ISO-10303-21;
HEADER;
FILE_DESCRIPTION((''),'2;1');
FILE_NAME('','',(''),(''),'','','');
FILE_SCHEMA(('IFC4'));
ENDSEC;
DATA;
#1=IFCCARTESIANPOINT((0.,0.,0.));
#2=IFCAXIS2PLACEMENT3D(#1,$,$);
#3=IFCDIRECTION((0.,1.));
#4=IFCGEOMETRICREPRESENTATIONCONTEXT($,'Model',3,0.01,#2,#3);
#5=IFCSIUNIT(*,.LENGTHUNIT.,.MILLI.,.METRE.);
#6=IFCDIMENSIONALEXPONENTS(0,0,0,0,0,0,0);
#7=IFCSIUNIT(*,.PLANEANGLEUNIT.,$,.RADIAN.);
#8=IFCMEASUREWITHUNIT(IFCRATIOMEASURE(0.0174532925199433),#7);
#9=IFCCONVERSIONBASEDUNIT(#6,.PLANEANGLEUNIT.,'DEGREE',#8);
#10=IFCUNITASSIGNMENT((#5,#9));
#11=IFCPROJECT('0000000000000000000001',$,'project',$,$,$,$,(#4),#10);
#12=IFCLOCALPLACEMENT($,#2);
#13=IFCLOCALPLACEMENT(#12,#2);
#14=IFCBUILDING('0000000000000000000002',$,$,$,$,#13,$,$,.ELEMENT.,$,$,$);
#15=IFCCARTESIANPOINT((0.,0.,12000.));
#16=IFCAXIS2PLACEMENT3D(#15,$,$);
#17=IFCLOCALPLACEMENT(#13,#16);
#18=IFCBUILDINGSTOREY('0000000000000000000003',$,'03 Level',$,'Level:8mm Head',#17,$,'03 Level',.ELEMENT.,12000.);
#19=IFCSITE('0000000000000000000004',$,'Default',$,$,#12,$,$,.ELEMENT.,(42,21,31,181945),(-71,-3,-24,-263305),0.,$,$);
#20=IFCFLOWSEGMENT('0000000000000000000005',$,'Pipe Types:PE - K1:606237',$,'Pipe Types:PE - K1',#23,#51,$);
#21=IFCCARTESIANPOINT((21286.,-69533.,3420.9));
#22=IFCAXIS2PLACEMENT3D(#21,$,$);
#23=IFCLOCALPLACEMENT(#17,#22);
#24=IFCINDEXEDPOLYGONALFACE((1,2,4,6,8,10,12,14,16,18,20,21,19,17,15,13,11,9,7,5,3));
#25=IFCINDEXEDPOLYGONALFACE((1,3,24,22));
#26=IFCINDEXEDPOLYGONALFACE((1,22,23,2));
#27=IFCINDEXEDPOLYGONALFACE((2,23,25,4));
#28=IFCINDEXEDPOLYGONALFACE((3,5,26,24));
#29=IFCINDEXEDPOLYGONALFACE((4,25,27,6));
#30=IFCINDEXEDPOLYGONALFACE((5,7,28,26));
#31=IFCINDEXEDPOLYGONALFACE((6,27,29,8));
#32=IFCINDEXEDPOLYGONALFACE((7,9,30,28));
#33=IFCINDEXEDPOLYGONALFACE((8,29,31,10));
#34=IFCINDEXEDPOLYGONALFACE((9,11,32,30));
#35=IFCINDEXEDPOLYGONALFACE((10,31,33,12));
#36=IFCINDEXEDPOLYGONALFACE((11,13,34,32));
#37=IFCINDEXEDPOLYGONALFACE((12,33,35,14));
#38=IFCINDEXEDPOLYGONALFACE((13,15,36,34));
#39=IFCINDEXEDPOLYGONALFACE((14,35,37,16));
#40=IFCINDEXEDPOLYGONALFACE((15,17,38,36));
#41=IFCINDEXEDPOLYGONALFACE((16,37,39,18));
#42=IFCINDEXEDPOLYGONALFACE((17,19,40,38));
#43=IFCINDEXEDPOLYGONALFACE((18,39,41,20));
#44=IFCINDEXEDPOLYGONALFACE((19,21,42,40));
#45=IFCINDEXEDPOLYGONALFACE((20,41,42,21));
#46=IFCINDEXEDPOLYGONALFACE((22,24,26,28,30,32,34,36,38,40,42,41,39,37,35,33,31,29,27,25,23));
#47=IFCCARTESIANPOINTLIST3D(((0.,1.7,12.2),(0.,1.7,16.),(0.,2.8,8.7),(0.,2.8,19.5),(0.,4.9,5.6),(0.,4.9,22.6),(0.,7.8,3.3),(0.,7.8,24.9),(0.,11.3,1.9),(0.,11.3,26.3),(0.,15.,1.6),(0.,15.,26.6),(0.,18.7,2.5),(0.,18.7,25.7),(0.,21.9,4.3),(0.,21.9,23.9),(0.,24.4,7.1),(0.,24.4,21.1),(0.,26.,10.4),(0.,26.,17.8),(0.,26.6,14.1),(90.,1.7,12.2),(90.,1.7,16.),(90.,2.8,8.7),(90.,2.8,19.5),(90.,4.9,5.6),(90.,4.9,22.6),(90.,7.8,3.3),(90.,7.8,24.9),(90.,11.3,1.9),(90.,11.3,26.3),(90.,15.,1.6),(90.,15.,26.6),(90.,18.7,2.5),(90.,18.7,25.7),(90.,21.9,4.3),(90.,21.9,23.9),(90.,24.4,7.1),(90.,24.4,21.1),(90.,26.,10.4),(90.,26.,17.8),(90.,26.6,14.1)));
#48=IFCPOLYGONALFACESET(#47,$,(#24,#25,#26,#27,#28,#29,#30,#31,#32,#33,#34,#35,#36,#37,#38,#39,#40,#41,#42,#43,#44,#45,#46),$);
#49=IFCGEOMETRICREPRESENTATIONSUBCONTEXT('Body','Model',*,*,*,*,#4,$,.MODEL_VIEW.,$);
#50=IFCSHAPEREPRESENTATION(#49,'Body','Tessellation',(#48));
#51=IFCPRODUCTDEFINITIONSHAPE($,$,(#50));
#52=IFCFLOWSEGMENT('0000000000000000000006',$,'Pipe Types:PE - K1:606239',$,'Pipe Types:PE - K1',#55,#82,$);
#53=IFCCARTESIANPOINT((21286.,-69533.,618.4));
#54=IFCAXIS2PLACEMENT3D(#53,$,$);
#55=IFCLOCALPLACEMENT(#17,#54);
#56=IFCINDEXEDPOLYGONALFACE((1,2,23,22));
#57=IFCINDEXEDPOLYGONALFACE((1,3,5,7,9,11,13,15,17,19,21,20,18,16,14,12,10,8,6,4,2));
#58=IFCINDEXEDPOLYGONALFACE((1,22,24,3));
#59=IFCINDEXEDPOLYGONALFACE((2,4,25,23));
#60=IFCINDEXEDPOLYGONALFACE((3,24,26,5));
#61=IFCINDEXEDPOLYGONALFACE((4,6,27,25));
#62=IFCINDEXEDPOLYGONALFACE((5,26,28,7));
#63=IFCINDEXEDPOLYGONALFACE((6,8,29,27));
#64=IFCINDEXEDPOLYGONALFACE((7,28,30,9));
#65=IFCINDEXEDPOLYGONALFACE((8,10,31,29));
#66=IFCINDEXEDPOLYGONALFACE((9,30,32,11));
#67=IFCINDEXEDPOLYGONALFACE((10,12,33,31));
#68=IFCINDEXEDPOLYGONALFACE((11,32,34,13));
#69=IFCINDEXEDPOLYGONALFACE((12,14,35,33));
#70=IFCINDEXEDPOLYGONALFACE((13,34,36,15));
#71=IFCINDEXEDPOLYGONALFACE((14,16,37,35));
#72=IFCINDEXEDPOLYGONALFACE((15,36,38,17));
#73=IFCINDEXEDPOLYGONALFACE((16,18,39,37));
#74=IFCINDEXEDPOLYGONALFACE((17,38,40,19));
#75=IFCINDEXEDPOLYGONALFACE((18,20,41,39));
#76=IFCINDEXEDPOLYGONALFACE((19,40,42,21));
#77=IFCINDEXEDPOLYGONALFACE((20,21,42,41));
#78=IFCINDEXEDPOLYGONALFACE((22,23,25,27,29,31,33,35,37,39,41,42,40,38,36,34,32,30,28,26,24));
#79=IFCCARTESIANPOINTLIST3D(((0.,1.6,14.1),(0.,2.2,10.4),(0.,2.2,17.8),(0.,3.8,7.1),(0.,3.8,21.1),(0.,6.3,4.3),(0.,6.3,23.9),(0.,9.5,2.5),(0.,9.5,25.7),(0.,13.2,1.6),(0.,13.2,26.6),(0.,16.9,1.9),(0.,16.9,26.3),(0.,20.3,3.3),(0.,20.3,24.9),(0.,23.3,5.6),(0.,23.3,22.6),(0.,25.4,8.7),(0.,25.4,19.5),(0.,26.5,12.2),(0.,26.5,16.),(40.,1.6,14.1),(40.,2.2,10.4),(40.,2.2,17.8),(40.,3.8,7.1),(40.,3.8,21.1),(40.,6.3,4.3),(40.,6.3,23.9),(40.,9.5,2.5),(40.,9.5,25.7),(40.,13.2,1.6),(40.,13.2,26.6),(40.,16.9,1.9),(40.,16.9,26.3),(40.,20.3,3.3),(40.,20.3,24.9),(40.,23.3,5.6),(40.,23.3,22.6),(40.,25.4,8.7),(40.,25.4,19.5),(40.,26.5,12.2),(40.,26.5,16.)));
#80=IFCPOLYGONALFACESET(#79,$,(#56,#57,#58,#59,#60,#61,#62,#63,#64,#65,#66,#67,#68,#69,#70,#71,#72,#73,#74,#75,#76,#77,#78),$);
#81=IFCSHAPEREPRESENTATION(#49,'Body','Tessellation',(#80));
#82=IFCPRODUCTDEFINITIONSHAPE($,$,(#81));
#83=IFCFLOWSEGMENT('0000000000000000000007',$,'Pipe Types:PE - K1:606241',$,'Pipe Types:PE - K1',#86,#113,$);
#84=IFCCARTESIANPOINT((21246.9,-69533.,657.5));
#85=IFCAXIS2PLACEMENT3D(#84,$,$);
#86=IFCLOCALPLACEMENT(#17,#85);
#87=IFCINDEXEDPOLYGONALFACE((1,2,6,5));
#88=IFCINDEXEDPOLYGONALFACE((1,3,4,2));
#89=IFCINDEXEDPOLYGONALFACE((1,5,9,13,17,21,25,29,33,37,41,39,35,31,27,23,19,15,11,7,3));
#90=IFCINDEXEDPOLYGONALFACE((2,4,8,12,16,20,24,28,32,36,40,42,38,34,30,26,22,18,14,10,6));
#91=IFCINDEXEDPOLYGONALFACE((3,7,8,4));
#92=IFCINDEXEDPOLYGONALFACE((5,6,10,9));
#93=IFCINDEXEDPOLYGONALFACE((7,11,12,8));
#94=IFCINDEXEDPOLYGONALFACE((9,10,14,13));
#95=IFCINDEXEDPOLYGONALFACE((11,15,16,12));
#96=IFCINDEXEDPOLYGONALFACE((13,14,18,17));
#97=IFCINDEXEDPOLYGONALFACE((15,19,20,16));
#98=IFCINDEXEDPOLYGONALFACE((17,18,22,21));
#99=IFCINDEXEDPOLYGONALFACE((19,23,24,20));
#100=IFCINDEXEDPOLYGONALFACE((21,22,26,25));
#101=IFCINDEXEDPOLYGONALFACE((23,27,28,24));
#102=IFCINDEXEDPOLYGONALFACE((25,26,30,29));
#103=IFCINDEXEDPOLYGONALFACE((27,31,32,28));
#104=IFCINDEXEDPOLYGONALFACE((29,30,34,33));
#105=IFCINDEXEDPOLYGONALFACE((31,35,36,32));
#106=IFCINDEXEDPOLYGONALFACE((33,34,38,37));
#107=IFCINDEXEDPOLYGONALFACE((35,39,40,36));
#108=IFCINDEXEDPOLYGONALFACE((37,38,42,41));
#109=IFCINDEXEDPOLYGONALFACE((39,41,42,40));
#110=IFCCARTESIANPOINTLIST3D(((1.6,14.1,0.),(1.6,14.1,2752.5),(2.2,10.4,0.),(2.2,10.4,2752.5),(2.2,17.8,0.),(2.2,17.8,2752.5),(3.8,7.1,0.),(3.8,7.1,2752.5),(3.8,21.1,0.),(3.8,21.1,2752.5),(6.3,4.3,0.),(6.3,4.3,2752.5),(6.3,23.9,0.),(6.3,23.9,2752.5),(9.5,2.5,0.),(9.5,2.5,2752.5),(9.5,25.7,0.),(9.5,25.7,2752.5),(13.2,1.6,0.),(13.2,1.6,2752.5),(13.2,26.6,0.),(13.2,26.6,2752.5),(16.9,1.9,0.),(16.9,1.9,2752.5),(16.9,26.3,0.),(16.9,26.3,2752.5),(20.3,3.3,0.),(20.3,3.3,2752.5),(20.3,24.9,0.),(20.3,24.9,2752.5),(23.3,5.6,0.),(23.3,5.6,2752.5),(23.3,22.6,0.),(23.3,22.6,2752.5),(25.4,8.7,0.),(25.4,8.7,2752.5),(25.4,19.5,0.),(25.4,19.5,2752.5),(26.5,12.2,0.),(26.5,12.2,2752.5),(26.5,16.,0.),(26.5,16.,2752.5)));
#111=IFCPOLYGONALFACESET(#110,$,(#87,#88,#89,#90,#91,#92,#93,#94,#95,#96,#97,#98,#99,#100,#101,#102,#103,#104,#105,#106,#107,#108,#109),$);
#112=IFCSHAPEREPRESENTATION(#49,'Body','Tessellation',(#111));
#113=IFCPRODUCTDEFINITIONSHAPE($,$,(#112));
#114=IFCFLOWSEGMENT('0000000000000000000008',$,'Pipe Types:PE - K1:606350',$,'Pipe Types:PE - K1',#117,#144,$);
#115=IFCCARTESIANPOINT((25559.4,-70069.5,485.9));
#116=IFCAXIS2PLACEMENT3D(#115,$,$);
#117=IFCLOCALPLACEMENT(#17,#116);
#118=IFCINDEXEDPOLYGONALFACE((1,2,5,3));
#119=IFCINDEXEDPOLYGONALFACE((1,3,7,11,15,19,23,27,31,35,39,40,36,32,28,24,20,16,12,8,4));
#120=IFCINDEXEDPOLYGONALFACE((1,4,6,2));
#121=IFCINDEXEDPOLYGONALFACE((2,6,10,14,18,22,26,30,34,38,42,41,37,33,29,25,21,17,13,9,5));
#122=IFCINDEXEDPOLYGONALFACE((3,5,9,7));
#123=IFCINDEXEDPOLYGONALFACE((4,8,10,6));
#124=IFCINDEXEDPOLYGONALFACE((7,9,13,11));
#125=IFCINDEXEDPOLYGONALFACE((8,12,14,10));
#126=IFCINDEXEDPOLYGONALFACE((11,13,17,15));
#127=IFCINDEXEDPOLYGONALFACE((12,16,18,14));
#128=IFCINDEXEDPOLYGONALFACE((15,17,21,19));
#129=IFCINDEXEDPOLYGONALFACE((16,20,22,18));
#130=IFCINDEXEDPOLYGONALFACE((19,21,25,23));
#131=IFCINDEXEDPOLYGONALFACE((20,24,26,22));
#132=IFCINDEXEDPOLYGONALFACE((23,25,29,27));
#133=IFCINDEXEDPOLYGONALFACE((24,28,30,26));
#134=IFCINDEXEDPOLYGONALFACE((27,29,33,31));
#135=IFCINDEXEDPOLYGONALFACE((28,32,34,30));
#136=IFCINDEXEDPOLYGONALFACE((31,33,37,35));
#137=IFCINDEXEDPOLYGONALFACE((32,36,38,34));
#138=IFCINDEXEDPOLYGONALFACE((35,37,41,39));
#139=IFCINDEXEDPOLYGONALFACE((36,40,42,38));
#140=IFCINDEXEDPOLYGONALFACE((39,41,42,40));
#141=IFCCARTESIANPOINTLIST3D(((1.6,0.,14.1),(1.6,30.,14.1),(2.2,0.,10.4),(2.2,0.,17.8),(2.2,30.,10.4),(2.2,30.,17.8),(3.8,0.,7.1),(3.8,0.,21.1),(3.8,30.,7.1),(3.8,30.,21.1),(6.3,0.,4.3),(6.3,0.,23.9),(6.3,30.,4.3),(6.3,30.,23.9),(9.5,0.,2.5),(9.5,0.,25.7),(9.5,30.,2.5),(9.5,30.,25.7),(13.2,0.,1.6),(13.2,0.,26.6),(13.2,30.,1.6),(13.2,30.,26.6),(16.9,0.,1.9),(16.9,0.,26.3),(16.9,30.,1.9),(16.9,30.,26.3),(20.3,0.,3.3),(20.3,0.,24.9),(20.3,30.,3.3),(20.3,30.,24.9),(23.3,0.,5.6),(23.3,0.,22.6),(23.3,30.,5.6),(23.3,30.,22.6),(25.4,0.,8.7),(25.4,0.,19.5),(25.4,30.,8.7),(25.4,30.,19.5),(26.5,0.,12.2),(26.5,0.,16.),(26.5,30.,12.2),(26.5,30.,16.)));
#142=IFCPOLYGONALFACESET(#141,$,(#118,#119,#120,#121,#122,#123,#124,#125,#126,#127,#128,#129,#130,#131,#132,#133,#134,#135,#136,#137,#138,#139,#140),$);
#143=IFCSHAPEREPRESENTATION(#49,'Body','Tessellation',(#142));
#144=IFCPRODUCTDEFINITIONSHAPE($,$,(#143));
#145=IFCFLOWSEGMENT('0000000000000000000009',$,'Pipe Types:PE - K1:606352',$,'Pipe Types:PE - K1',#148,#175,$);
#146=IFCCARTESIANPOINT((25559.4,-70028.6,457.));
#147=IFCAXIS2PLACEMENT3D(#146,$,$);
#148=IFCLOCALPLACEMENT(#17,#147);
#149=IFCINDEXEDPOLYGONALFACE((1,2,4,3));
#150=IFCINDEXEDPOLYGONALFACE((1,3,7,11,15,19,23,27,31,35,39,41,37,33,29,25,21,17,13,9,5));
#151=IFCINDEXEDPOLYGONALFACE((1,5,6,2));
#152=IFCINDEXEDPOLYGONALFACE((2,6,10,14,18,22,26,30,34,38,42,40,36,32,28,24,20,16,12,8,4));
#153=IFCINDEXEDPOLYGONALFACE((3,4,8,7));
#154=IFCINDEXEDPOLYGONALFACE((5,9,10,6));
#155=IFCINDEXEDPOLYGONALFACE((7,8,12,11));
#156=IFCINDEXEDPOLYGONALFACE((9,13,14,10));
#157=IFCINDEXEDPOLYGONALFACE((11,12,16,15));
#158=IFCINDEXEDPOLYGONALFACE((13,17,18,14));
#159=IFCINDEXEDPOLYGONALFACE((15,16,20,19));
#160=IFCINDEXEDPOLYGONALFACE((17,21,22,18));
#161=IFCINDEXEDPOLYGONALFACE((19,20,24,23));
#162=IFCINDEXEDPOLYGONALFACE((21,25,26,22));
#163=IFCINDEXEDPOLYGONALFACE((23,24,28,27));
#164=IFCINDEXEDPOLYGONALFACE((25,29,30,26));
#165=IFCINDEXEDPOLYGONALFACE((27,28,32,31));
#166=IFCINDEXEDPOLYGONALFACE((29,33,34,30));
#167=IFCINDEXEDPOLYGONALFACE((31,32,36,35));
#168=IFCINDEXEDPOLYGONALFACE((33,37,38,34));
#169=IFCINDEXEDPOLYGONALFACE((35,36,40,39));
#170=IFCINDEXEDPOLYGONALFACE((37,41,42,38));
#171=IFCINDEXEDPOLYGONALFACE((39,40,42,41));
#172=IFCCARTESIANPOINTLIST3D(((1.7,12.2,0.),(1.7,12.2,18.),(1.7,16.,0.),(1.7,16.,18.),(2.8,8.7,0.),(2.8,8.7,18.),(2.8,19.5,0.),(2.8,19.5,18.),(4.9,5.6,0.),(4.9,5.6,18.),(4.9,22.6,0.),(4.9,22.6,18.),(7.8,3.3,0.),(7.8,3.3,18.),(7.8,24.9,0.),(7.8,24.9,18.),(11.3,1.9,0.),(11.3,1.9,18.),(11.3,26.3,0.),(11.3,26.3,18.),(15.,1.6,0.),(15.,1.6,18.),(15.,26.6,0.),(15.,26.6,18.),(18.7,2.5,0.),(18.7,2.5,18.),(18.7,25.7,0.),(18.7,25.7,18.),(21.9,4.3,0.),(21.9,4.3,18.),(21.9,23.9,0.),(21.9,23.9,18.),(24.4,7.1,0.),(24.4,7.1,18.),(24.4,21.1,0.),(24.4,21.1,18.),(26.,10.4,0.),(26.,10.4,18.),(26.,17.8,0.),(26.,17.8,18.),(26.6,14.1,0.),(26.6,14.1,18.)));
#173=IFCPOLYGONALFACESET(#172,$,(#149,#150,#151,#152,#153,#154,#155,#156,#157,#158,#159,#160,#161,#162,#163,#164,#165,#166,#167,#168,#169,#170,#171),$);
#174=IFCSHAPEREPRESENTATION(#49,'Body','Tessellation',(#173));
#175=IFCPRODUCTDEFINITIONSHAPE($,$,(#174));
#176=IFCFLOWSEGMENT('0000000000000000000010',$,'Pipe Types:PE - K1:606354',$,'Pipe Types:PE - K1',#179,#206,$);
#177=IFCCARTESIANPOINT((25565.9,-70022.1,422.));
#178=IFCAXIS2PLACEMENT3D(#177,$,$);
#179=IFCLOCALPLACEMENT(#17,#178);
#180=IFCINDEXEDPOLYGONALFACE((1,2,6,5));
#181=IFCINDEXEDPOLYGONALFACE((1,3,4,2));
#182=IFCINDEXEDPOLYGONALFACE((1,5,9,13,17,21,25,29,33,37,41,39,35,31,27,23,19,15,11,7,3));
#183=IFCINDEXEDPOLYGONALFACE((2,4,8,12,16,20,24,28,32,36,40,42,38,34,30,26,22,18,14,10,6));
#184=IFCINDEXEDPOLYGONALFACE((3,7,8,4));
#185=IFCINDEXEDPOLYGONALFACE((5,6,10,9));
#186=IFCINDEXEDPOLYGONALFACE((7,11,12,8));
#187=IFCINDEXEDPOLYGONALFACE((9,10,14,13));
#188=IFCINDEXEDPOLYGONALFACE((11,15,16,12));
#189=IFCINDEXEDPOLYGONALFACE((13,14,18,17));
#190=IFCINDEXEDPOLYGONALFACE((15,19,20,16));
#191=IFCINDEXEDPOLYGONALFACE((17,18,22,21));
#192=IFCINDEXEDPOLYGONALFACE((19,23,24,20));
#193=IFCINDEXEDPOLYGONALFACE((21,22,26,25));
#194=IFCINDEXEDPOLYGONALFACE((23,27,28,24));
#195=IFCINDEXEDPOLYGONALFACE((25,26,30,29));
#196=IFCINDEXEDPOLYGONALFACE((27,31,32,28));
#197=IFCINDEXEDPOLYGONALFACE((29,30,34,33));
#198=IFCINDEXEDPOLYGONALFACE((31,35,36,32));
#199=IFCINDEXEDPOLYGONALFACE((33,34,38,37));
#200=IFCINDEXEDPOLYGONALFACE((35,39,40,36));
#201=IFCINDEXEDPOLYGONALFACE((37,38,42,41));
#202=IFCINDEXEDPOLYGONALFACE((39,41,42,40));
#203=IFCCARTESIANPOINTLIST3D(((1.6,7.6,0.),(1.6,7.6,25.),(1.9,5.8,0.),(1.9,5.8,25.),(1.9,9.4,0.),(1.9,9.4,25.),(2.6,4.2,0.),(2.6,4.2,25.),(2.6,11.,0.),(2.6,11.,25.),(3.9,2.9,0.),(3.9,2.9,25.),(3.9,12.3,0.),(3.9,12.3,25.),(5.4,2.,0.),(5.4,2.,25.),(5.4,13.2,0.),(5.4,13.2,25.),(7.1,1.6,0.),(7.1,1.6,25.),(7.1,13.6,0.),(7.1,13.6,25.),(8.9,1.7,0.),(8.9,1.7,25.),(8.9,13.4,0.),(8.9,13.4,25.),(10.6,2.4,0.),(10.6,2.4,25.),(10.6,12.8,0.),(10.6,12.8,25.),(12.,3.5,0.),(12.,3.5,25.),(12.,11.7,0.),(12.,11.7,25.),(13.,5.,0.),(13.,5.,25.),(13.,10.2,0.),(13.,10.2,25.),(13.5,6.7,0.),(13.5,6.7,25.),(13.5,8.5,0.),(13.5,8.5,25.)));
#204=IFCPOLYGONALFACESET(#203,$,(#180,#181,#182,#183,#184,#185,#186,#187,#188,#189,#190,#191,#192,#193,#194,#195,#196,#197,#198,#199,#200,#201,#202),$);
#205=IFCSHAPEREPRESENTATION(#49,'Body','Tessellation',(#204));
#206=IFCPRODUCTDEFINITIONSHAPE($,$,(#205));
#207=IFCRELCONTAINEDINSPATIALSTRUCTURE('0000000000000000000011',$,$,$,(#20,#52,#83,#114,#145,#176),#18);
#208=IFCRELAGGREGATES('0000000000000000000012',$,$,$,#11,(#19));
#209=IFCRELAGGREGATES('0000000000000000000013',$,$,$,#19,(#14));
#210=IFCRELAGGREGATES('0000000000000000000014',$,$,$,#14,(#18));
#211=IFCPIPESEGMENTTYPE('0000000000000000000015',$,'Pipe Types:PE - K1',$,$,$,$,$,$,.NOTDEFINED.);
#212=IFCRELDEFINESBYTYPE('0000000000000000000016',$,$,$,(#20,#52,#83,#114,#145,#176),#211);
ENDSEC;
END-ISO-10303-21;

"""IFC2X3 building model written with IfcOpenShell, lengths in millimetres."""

from ifc_helpers import new_model, entity, si_unit, converted_unit, direction, frame, frame_2d, origin, origin_2d_with_axis, place, context, subcontext, project, spatial, circle, extrude, type_object, element, save


model = new_model("IFC2X3")

# Units and contexts
model_context = context("Model", 3, precision=0.01, world=origin(), true_north=direction((0.0, 1.0)))
body_context = subcontext(model_context, "Body", "Model", "MODEL_VIEW")
ifc_project = project(units=[si_unit("LENGTHUNIT", "METRE", prefix="MILLI"), converted_unit("PLANEANGLEUNIT", "DEGREE", entity("IfcRatioMeasure", 0.0174532925199433), si_unit("PLANEANGLEUNIT", "RADIAN"), dimensions=[0, 0, 0, 0, 0, 0, 0])], contexts=[model_context])

# Site, building, storey
site_placement = place(None, origin())
site = spatial("IfcSite", under=ifc_project, at=site_placement, Name="Default", CompositionType="ELEMENT", RefLatitude=(42, 21, 31, 181945), RefLongitude=(-71, -3, -24, -263305), RefElevation=0.0)
building_placement = place(site_placement, origin())
building = spatial("IfcBuilding", under=site, at=building_placement, CompositionType="ELEMENT")
storey_placement = place(building_placement, frame((0.0, 0.0, 12000.0)))
storey = spatial("IfcBuildingStorey", under=building, at=storey_placement, Name="03 Level", ObjectType="Level:8mm Head", LongName="03 Level", CompositionType="ELEMENT", Elevation=12000.0)

# Flow segments
pipe_segment_type = type_object("IfcPipeSegmentType", Name="Pipe Types:PE - K1", PredefinedType="NOTDEFINED")
flow_segment_1_placement = place(storey_placement, frame((21286.0, -69533.0, 3420.9)))
element("IfcFlowSegment", 1, at=flow_segment_1_placement, inside=storey, type_object=pipe_segment_type, Name="Pipe Types:PE - K1:606237", ObjectType="Pipe Types:PE - K1", context=body_context, shape_type="SweptSolid", body=[
    extrude(circle(Radius=12.5, at=frame_2d((0.0, 0.0), x_axis=(1.0, 0.0))), frame((0.0, 14.1, 14.1), z_axis=(1.0, 0.0, 0.0), x_axis=(0.0, 1.0, 0.0)), (0.0, 0.0, 1.0), 90.0),
])
flow_segment_2_placement = place(storey_placement, frame((21286.0, -69533.0, 618.4)))
element("IfcFlowSegment", 2, at=flow_segment_2_placement, inside=storey, type_object=pipe_segment_type, Name="Pipe Types:PE - K1:606239", ObjectType="Pipe Types:PE - K1", context=body_context, shape_type="SweptSolid", body=[
    extrude(circle(Radius=12.5, at=frame_2d((0.0, 0.0), x_axis=(1.0, 0.0))), frame((0.0, 14.1, 14.1), z_axis=(1.0, 0.0, 0.0), x_axis=(0.0, -1.0, 0.0)), (0.0, 0.0, 1.0), 40.0),
])
flow_segment_3_placement = place(storey_placement, frame((21246.9, -69533.0, 657.5)))
element("IfcFlowSegment", 3, at=flow_segment_3_placement, inside=storey, type_object=pipe_segment_type, Name="Pipe Types:PE - K1:606241", ObjectType="Pipe Types:PE - K1", context=body_context, shape_type="SweptSolid", body=[
    extrude(circle(Radius=12.5, at=frame_2d((0.0, 0.0), x_axis=(1.0, 0.0))), frame((14.1, 14.1, 0.0), z_axis=(0.0, 0.0, 1.0), x_axis=(-1.0, 0.0, 0.0)), (0.0, 0.0, 1.0), 2752.5),
])
flow_segment_4_placement = place(storey_placement, frame((25559.4, -70069.5, 485.9)))
element("IfcFlowSegment", 4, at=flow_segment_4_placement, inside=storey, type_object=pipe_segment_type, Name="Pipe Types:PE - K1:606350", ObjectType="Pipe Types:PE - K1", context=body_context, shape_type="SweptSolid", body=[
    extrude(circle(Radius=12.5, at=origin_2d_with_axis()), frame((14.1, 0.0, 14.1), z_axis=(0.0, 1.0, 0.0), x_axis=(-1.0, 0.0, 0.0)), (0.0, 0.0, 1.0), 30.0),
])
flow_segment_5_placement = place(storey_placement, frame((25559.4, -70028.6, 457.0)))
element("IfcFlowSegment", 5, at=flow_segment_5_placement, inside=storey, type_object=pipe_segment_type, Name="Pipe Types:PE - K1:606352", ObjectType="Pipe Types:PE - K1", context=body_context, shape_type="SweptSolid", body=[
    extrude(circle(Radius=12.5, at=origin_2d_with_axis()), frame((14.1, 14.1, 0.0)), (0.0, 0.0, 1.0), 18.0),
])
flow_segment_6_placement = place(storey_placement, frame((25565.9, -70022.1, 422.0)))
element("IfcFlowSegment", 6, at=flow_segment_6_placement, inside=storey, type_object=pipe_segment_type, Name="Pipe Types:PE - K1:606354", ObjectType="Pipe Types:PE - K1", context=body_context, shape_type="SweptSolid", body=[
    extrude(circle(Radius=6.0, at=origin_2d_with_axis()), frame((7.6, 7.6, 0.0), z_axis=(0.0, 0.0, 1.0), x_axis=(-1.0, 0.0, 0.0)), (0.0, 0.0, 1.0), 25.0),
])

save(model, "model.ifc")
